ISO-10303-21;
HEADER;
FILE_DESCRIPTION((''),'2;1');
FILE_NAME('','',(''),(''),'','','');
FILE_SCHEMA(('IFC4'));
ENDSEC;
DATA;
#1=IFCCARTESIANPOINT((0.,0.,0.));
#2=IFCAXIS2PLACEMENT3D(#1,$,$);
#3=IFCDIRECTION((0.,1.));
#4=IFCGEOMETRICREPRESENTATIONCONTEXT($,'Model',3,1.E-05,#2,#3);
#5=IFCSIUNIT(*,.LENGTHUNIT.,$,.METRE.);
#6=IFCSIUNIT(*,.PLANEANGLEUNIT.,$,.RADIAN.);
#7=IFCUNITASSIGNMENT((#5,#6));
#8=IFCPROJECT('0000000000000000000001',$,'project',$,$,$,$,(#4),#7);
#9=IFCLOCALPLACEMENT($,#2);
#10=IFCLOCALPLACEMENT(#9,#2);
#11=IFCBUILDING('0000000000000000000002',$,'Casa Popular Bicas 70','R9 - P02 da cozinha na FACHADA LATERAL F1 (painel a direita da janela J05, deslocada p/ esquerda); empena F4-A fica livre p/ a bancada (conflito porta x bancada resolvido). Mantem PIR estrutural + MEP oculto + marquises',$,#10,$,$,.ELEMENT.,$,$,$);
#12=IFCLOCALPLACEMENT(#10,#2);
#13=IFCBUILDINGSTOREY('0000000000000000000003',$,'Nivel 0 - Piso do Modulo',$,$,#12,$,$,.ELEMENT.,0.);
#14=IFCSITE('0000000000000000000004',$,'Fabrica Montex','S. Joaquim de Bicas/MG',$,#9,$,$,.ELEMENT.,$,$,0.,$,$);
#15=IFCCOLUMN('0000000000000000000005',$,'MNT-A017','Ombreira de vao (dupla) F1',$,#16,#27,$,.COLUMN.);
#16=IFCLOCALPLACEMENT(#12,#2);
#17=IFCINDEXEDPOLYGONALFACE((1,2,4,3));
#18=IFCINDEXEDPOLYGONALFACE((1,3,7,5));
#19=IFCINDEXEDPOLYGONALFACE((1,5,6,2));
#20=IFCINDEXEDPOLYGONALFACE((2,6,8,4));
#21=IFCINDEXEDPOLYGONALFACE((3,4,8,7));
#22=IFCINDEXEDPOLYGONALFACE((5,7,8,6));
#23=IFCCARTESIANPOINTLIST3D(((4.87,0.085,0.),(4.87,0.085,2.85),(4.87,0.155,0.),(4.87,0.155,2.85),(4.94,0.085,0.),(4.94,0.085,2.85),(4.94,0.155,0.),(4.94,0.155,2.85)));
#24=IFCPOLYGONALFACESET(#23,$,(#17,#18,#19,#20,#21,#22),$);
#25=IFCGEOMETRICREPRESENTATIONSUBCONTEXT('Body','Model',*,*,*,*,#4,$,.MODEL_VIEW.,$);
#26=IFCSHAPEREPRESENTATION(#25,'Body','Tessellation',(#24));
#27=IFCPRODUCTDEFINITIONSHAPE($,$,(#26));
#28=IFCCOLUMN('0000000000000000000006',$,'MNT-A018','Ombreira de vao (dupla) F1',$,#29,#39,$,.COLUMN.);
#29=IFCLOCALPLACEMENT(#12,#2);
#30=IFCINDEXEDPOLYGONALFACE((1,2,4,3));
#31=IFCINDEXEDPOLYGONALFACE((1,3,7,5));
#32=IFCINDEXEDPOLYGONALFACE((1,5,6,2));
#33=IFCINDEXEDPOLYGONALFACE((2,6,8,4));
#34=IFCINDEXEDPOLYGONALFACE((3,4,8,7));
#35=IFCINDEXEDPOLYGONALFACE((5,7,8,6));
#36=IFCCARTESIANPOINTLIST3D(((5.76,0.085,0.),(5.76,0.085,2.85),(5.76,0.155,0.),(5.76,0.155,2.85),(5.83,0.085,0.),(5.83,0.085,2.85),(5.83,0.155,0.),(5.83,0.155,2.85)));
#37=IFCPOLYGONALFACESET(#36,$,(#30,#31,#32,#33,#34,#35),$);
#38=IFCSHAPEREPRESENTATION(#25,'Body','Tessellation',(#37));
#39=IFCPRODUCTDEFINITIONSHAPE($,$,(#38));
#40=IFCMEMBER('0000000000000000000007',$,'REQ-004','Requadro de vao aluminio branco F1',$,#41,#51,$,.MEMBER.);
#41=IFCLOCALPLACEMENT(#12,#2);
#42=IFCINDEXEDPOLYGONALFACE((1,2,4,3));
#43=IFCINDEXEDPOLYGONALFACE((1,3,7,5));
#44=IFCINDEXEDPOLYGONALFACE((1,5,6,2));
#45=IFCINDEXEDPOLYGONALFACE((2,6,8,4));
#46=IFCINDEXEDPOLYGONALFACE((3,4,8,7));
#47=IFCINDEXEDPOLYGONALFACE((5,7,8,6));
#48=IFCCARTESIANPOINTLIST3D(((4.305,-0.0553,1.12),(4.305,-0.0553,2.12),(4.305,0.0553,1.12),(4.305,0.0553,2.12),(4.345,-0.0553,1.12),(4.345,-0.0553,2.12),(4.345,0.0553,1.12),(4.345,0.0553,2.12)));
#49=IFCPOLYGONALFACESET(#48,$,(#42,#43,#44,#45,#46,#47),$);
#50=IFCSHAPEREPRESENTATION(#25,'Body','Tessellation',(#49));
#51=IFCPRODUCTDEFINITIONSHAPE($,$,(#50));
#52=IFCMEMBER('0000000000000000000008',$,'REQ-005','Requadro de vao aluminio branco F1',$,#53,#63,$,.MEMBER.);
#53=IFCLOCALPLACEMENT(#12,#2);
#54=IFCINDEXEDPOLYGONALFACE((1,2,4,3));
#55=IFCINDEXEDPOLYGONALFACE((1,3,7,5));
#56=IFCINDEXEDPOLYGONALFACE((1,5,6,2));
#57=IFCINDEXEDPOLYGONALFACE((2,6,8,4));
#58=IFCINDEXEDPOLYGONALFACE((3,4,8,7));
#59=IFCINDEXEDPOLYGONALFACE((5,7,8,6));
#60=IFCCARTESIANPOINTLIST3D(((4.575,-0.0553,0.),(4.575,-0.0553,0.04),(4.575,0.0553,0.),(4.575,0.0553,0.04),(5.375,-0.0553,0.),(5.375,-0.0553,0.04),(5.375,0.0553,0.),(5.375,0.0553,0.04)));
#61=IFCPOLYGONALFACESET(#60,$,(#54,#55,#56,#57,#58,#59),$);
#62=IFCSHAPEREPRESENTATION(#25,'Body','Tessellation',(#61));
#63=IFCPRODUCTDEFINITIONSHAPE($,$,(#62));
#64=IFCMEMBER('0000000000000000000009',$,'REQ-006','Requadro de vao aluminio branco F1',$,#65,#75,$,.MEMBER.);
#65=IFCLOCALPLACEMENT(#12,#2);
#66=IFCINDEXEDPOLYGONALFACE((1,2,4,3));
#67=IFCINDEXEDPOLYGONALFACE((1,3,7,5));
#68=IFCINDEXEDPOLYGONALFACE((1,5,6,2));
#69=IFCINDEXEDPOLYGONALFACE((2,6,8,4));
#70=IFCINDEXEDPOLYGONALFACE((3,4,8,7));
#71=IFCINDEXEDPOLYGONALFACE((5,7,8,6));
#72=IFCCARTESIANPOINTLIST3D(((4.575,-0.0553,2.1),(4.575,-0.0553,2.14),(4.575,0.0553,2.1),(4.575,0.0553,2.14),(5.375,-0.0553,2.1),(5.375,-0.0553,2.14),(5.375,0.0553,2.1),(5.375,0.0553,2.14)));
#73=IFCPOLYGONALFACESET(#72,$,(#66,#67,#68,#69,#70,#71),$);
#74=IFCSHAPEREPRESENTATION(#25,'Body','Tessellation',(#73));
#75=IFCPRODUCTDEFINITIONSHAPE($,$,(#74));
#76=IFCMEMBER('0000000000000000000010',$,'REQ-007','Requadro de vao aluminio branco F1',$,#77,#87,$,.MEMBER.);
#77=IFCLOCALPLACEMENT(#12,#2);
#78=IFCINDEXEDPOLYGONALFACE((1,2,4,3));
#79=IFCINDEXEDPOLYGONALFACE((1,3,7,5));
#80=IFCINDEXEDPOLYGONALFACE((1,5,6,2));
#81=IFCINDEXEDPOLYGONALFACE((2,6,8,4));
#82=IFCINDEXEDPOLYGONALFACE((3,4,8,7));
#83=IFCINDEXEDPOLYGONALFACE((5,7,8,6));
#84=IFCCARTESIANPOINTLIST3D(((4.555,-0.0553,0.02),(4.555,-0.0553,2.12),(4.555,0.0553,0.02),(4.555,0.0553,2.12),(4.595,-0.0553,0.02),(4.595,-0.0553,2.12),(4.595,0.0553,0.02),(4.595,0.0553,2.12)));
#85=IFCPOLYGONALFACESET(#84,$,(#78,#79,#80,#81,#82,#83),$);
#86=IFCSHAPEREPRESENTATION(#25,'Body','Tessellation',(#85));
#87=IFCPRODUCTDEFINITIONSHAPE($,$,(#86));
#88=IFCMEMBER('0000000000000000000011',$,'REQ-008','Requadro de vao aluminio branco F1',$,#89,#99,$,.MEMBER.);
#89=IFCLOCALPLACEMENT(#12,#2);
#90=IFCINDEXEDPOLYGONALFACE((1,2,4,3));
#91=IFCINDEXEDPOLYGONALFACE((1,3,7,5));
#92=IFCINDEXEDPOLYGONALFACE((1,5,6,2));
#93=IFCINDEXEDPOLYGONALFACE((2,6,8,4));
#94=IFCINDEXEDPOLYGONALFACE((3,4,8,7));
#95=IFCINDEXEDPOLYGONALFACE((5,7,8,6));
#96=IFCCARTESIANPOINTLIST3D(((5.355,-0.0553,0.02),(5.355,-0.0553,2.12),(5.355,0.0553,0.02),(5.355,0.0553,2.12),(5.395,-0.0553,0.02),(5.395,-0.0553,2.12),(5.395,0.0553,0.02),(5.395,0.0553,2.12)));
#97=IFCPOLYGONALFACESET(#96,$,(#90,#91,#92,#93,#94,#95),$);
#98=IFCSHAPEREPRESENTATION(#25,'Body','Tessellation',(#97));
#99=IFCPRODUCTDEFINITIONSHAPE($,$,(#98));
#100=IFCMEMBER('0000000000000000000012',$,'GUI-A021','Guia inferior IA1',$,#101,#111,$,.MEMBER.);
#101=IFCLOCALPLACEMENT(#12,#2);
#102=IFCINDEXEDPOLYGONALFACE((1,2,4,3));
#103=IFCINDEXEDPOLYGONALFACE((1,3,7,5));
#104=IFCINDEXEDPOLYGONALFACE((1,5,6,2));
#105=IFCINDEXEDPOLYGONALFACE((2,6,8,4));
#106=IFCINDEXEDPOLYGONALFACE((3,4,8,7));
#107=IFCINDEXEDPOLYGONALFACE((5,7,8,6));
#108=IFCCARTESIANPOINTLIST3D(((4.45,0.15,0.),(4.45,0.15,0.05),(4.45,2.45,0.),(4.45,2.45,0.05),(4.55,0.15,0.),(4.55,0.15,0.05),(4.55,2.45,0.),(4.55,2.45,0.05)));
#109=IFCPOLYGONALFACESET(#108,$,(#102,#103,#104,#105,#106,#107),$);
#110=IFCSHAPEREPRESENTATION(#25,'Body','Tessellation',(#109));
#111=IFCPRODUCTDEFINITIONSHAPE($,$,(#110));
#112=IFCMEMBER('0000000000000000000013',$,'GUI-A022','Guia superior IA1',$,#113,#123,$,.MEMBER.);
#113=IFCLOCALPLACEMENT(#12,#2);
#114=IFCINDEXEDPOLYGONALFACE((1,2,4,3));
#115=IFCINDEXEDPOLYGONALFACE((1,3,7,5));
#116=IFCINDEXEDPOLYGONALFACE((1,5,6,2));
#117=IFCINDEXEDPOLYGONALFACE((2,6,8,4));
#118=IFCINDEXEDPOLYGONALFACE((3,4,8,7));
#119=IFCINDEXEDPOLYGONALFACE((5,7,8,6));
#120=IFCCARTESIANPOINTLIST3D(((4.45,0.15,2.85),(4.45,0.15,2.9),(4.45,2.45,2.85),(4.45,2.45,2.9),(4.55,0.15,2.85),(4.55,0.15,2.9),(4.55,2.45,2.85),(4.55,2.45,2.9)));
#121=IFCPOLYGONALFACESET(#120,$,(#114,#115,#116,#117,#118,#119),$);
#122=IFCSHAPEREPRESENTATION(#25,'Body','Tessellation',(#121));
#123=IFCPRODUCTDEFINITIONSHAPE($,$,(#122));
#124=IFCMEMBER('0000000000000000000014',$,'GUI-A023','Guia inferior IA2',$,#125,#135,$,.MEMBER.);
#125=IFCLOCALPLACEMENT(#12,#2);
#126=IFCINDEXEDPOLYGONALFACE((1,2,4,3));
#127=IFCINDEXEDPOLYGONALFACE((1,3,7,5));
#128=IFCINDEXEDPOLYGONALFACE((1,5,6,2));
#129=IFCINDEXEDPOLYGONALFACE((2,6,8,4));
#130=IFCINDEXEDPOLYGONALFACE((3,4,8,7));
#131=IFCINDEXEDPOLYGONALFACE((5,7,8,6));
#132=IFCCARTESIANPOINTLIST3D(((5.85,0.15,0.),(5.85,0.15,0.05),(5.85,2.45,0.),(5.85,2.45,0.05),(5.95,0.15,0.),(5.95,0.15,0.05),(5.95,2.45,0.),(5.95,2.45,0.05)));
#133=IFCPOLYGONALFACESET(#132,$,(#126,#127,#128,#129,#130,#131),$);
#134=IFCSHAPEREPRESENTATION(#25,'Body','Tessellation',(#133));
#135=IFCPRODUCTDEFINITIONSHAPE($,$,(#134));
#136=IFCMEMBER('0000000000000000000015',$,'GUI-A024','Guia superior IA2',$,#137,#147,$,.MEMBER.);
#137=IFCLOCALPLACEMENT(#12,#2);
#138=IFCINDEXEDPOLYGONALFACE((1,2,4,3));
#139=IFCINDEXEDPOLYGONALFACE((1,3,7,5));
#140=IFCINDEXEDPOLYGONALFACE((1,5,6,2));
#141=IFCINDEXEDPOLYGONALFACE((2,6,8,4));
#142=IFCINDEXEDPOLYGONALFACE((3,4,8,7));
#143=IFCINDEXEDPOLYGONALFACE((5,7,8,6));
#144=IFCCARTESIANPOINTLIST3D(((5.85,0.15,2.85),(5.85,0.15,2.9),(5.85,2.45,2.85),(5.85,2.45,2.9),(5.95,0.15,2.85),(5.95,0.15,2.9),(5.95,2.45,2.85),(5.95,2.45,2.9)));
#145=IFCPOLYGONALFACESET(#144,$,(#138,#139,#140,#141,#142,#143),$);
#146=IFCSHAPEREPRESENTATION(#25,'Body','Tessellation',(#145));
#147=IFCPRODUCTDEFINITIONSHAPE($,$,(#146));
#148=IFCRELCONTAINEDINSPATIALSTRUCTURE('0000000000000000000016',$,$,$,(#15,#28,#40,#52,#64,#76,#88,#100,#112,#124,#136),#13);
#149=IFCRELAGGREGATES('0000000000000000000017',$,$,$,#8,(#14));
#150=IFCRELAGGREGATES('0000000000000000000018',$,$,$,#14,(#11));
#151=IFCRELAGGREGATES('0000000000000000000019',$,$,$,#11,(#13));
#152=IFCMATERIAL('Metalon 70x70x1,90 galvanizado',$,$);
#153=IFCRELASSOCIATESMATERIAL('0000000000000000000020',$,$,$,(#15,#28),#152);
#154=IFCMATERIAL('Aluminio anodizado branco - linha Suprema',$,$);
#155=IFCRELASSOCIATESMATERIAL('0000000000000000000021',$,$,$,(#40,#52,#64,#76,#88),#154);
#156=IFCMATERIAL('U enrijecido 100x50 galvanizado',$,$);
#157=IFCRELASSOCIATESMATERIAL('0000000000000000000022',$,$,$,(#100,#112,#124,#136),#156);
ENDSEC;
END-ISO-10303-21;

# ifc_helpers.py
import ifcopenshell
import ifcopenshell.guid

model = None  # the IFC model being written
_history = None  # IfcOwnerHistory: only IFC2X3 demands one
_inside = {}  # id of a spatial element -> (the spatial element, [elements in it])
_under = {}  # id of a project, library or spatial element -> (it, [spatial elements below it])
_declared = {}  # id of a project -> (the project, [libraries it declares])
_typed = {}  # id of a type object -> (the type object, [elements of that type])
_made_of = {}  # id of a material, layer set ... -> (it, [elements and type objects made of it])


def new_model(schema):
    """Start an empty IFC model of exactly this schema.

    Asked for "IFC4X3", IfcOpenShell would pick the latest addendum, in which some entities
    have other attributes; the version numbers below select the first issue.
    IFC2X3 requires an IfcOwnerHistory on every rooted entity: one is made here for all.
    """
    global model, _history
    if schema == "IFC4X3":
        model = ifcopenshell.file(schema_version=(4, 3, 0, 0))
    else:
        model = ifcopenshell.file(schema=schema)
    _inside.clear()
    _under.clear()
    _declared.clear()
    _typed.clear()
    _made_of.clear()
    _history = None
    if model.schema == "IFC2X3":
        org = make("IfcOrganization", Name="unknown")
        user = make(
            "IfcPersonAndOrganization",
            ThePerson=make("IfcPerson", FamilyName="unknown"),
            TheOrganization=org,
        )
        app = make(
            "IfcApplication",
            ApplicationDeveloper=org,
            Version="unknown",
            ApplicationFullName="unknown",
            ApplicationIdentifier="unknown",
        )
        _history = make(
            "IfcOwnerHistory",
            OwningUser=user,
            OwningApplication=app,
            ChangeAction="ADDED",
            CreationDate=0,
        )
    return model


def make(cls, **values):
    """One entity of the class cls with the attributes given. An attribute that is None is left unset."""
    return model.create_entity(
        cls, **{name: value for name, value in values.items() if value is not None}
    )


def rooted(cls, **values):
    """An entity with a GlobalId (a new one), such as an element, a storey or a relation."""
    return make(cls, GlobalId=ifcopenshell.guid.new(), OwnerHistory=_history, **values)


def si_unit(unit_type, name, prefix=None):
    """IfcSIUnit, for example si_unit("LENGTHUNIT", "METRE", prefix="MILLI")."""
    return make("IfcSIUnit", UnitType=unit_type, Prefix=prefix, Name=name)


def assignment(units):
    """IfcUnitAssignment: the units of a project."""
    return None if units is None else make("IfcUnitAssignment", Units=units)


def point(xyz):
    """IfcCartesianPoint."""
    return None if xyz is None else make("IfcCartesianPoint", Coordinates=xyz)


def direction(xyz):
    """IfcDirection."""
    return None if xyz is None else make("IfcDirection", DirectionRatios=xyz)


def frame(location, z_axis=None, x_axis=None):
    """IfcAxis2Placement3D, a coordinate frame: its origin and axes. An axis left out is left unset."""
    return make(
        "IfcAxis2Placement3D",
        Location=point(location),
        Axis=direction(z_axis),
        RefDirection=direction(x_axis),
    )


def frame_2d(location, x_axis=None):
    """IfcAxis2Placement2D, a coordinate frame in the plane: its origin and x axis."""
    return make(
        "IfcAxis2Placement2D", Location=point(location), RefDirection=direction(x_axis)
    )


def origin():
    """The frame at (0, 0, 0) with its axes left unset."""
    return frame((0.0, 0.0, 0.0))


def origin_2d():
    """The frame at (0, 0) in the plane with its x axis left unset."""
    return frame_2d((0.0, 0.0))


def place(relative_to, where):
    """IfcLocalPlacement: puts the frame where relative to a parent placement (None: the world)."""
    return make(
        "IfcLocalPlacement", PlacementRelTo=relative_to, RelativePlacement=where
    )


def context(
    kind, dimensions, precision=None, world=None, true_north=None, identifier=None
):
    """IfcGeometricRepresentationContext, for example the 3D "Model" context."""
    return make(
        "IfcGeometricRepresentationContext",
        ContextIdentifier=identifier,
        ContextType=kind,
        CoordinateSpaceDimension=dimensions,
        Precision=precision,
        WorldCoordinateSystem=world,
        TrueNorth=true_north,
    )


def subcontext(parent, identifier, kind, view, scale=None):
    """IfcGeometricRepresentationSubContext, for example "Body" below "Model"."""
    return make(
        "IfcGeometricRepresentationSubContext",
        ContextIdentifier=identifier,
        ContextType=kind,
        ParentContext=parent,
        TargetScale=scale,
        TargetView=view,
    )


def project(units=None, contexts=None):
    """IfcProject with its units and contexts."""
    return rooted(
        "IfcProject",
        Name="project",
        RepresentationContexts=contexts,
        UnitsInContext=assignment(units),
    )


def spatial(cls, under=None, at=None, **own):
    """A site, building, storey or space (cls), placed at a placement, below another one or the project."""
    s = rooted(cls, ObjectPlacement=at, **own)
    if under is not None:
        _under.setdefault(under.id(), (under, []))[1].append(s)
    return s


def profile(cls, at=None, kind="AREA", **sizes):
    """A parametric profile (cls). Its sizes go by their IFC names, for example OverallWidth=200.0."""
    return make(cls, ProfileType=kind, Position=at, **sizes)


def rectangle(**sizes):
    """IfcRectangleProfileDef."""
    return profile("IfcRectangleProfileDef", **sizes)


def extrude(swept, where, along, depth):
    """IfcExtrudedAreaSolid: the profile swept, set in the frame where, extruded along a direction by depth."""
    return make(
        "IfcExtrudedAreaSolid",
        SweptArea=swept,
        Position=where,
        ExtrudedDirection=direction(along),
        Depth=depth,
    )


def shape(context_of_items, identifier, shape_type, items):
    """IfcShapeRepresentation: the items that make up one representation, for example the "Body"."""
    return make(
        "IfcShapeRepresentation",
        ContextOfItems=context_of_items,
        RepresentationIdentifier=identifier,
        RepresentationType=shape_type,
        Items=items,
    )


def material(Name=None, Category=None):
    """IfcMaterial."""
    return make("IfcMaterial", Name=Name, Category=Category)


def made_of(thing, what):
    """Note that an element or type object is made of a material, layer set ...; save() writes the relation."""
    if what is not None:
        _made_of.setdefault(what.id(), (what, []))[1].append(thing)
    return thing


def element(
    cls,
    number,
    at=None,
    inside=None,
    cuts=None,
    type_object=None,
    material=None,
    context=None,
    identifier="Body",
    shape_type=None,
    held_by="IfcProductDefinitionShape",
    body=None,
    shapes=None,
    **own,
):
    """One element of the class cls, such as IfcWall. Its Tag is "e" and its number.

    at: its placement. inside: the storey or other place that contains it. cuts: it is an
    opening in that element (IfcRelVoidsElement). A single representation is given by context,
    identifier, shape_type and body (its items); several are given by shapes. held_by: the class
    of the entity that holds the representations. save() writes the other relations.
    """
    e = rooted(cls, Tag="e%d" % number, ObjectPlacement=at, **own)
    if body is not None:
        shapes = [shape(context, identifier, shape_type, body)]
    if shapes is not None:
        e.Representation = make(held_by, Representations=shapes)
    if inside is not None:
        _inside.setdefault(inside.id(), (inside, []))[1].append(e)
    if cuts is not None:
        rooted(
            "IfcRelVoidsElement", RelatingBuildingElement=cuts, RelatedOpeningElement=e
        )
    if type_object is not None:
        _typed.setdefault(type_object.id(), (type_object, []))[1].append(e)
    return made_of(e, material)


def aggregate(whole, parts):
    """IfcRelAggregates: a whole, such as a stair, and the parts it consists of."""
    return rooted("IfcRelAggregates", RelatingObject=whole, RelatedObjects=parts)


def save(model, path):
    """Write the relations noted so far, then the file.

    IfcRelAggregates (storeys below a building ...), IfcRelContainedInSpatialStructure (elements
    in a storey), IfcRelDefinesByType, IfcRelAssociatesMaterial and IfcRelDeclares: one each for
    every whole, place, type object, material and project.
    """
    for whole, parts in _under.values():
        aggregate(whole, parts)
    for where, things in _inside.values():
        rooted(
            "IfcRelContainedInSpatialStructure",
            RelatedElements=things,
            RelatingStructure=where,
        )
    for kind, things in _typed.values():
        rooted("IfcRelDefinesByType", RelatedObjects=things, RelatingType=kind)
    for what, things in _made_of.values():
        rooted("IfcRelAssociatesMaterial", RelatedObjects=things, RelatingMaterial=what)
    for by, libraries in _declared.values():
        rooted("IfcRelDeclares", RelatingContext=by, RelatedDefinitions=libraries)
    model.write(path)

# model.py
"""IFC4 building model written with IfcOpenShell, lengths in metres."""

from ifc_helpers import new_model, si_unit, direction, frame, origin, origin_2d, place, context, subcontext, project, spatial, rectangle, extrude, material, element, save


model = new_model("IFC4")

# Units and contexts
model_context = context("Model", 3, precision=1e-05, world=origin(), true_north=direction((0.0, 1.0)))
body_context = subcontext(model_context, "Body", "Model", "MODEL_VIEW")
ifc_project = project(units=[si_unit("LENGTHUNIT", "METRE"), si_unit("PLANEANGLEUNIT", "RADIAN")], contexts=[model_context])

# Site, building, storey
site_placement = place(None, origin())
site = spatial("IfcSite", under=ifc_project, at=site_placement, Name="Fabrica Montex", Description="S. Joaquim de Bicas/MG", CompositionType="ELEMENT", RefElevation=0.0)
building_placement = place(site_placement, origin())
building = spatial("IfcBuilding", under=site, at=building_placement, Name="Casa Popular Bicas 70", Description="R9 - P02 da cozinha na FACHADA LATERAL F1 (painel a direita da janela J05, deslocada p/ esquerda); empena F4-A fica livre p/ a bancada (conflito porta x bancada resolvido). Mantem PIR estrutural + MEP oculto + marquises", CompositionType="ELEMENT")
storey_placement = place(building_placement, origin())
storey = spatial("IfcBuildingStorey", under=building, at=storey_placement, Name="Nivel 0 - Piso do Modulo", CompositionType="ELEMENT", Elevation=0.0)

# Columns
ifc_material_1 = material(Name="Metalon 70x70x1,90 galvanizado")
for number, where, name in (
    (1, (4.905, 0.12, 0.0), "MNT-A017"),
    (2, (5.795, 0.12, 0.0), "MNT-A018"),
):
    element("IfcColumn", number, at=place(storey_placement, frame(where)), inside=storey, material=ifc_material_1, Name=name, Description="Ombreira de vao (dupla) F1", PredefinedType="COLUMN", context=body_context, shape_type="SweptSolid", body=[
        extrude(rectangle(XDim=0.07, YDim=0.07, at=origin_2d()), origin(), (0.0, 0.0, 1.0), 2.85),
    ])

# Members
ifc_material_2 = material(Name="Aluminio anodizado branco - linha Suprema")
member_placement = place(storey_placement, frame((4.325, 0.0, 1.12), z_axis=(0.0, 0.0, 1.0), x_axis=(1.0, 0.0, 0.0)))
element("IfcMember", 3, at=member_placement, inside=storey, material=ifc_material_2, Name="REQ-004", Description="Requadro de vao aluminio branco F1", PredefinedType="MEMBER", context=body_context, shape_type="SweptSolid", body=[
    extrude(rectangle(XDim=0.04, YDim=0.1105, at=origin_2d()), origin(), (0.0, 0.0, 1.0), 1.0),
])
for number, where, z_axis, x_axis, name in (
    (4, (4.575, 0.0, 0.02), (1.0, 0.0, 0.0), (0.0, 0.0, 1.0), "REQ-005"),
    (5, (4.575, 0.0, 2.12), (1.0, 0.0, 0.0), (0.0, 0.0, 1.0), "REQ-006"),
):
    element("IfcMember", number, at=place(storey_placement, frame(where, z_axis=z_axis, x_axis=x_axis)), inside=storey, material=ifc_material_2, Name=name, Description="Requadro de vao aluminio branco F1", PredefinedType="MEMBER", context=body_context, shape_type="SweptSolid", body=[
        extrude(rectangle(XDim=0.04, YDim=0.1105, at=origin_2d()), origin(), (0.0, 0.0, 1.0), 0.8),
    ])
for number, where, z_axis, x_axis, name in (
    (6, (4.575, 0.0, 0.02), (0.0, 0.0, 1.0), (1.0, 0.0, 0.0), "REQ-007"),
    (7, (5.375, 0.0, 0.02), (0.0, 0.0, 1.0), (1.0, 0.0, 0.0), "REQ-008"),
):
    element("IfcMember", number, at=place(storey_placement, frame(where, z_axis=z_axis, x_axis=x_axis)), inside=storey, material=ifc_material_2, Name=name, Description="Requadro de vao aluminio branco F1", PredefinedType="MEMBER", context=body_context, shape_type="SweptSolid", body=[
        extrude(rectangle(XDim=0.04, YDim=0.1105, at=origin_2d()), origin(), (0.0, 0.0, 1.0), 2.1),
    ])
ifc_material_3 = material(Name="U enrijecido 100x50 galvanizado")
for number, where, z_axis, x_axis, name, description in (
    (8, (4.5, 0.15, 0.025), (0.0, 1.0, 0.0), (0.0, 0.0, 1.0), "GUI-A021", "Guia inferior IA1"),
    (9, (4.5, 0.15, 2.875), (0.0, 1.0, 0.0), (0.0, 0.0, 1.0), "GUI-A022", "Guia superior IA1"),
    (10, (5.9, 0.15, 0.025), (0.0, 1.0, 0.0), (0.0, 0.0, 1.0), "GUI-A023", "Guia inferior IA2"),
    (11, (5.9, 0.15, 2.875), (0.0, 1.0, 0.0), (0.0, 0.0, 1.0), "GUI-A024", "Guia superior IA2"),
):
    element("IfcMember", number, at=place(storey_placement, frame(where, z_axis=z_axis, x_axis=x_axis)), inside=storey, material=ifc_material_3, Name=name, Description=description, PredefinedType="MEMBER", context=body_context, shape_type="SweptSolid", body=[
        extrude(rectangle(XDim=0.05, YDim=0.1, at=origin_2d()), origin(), (0.0, 0.0, 1.0), 2.3),
    ])

save(model, "model.ifc")
